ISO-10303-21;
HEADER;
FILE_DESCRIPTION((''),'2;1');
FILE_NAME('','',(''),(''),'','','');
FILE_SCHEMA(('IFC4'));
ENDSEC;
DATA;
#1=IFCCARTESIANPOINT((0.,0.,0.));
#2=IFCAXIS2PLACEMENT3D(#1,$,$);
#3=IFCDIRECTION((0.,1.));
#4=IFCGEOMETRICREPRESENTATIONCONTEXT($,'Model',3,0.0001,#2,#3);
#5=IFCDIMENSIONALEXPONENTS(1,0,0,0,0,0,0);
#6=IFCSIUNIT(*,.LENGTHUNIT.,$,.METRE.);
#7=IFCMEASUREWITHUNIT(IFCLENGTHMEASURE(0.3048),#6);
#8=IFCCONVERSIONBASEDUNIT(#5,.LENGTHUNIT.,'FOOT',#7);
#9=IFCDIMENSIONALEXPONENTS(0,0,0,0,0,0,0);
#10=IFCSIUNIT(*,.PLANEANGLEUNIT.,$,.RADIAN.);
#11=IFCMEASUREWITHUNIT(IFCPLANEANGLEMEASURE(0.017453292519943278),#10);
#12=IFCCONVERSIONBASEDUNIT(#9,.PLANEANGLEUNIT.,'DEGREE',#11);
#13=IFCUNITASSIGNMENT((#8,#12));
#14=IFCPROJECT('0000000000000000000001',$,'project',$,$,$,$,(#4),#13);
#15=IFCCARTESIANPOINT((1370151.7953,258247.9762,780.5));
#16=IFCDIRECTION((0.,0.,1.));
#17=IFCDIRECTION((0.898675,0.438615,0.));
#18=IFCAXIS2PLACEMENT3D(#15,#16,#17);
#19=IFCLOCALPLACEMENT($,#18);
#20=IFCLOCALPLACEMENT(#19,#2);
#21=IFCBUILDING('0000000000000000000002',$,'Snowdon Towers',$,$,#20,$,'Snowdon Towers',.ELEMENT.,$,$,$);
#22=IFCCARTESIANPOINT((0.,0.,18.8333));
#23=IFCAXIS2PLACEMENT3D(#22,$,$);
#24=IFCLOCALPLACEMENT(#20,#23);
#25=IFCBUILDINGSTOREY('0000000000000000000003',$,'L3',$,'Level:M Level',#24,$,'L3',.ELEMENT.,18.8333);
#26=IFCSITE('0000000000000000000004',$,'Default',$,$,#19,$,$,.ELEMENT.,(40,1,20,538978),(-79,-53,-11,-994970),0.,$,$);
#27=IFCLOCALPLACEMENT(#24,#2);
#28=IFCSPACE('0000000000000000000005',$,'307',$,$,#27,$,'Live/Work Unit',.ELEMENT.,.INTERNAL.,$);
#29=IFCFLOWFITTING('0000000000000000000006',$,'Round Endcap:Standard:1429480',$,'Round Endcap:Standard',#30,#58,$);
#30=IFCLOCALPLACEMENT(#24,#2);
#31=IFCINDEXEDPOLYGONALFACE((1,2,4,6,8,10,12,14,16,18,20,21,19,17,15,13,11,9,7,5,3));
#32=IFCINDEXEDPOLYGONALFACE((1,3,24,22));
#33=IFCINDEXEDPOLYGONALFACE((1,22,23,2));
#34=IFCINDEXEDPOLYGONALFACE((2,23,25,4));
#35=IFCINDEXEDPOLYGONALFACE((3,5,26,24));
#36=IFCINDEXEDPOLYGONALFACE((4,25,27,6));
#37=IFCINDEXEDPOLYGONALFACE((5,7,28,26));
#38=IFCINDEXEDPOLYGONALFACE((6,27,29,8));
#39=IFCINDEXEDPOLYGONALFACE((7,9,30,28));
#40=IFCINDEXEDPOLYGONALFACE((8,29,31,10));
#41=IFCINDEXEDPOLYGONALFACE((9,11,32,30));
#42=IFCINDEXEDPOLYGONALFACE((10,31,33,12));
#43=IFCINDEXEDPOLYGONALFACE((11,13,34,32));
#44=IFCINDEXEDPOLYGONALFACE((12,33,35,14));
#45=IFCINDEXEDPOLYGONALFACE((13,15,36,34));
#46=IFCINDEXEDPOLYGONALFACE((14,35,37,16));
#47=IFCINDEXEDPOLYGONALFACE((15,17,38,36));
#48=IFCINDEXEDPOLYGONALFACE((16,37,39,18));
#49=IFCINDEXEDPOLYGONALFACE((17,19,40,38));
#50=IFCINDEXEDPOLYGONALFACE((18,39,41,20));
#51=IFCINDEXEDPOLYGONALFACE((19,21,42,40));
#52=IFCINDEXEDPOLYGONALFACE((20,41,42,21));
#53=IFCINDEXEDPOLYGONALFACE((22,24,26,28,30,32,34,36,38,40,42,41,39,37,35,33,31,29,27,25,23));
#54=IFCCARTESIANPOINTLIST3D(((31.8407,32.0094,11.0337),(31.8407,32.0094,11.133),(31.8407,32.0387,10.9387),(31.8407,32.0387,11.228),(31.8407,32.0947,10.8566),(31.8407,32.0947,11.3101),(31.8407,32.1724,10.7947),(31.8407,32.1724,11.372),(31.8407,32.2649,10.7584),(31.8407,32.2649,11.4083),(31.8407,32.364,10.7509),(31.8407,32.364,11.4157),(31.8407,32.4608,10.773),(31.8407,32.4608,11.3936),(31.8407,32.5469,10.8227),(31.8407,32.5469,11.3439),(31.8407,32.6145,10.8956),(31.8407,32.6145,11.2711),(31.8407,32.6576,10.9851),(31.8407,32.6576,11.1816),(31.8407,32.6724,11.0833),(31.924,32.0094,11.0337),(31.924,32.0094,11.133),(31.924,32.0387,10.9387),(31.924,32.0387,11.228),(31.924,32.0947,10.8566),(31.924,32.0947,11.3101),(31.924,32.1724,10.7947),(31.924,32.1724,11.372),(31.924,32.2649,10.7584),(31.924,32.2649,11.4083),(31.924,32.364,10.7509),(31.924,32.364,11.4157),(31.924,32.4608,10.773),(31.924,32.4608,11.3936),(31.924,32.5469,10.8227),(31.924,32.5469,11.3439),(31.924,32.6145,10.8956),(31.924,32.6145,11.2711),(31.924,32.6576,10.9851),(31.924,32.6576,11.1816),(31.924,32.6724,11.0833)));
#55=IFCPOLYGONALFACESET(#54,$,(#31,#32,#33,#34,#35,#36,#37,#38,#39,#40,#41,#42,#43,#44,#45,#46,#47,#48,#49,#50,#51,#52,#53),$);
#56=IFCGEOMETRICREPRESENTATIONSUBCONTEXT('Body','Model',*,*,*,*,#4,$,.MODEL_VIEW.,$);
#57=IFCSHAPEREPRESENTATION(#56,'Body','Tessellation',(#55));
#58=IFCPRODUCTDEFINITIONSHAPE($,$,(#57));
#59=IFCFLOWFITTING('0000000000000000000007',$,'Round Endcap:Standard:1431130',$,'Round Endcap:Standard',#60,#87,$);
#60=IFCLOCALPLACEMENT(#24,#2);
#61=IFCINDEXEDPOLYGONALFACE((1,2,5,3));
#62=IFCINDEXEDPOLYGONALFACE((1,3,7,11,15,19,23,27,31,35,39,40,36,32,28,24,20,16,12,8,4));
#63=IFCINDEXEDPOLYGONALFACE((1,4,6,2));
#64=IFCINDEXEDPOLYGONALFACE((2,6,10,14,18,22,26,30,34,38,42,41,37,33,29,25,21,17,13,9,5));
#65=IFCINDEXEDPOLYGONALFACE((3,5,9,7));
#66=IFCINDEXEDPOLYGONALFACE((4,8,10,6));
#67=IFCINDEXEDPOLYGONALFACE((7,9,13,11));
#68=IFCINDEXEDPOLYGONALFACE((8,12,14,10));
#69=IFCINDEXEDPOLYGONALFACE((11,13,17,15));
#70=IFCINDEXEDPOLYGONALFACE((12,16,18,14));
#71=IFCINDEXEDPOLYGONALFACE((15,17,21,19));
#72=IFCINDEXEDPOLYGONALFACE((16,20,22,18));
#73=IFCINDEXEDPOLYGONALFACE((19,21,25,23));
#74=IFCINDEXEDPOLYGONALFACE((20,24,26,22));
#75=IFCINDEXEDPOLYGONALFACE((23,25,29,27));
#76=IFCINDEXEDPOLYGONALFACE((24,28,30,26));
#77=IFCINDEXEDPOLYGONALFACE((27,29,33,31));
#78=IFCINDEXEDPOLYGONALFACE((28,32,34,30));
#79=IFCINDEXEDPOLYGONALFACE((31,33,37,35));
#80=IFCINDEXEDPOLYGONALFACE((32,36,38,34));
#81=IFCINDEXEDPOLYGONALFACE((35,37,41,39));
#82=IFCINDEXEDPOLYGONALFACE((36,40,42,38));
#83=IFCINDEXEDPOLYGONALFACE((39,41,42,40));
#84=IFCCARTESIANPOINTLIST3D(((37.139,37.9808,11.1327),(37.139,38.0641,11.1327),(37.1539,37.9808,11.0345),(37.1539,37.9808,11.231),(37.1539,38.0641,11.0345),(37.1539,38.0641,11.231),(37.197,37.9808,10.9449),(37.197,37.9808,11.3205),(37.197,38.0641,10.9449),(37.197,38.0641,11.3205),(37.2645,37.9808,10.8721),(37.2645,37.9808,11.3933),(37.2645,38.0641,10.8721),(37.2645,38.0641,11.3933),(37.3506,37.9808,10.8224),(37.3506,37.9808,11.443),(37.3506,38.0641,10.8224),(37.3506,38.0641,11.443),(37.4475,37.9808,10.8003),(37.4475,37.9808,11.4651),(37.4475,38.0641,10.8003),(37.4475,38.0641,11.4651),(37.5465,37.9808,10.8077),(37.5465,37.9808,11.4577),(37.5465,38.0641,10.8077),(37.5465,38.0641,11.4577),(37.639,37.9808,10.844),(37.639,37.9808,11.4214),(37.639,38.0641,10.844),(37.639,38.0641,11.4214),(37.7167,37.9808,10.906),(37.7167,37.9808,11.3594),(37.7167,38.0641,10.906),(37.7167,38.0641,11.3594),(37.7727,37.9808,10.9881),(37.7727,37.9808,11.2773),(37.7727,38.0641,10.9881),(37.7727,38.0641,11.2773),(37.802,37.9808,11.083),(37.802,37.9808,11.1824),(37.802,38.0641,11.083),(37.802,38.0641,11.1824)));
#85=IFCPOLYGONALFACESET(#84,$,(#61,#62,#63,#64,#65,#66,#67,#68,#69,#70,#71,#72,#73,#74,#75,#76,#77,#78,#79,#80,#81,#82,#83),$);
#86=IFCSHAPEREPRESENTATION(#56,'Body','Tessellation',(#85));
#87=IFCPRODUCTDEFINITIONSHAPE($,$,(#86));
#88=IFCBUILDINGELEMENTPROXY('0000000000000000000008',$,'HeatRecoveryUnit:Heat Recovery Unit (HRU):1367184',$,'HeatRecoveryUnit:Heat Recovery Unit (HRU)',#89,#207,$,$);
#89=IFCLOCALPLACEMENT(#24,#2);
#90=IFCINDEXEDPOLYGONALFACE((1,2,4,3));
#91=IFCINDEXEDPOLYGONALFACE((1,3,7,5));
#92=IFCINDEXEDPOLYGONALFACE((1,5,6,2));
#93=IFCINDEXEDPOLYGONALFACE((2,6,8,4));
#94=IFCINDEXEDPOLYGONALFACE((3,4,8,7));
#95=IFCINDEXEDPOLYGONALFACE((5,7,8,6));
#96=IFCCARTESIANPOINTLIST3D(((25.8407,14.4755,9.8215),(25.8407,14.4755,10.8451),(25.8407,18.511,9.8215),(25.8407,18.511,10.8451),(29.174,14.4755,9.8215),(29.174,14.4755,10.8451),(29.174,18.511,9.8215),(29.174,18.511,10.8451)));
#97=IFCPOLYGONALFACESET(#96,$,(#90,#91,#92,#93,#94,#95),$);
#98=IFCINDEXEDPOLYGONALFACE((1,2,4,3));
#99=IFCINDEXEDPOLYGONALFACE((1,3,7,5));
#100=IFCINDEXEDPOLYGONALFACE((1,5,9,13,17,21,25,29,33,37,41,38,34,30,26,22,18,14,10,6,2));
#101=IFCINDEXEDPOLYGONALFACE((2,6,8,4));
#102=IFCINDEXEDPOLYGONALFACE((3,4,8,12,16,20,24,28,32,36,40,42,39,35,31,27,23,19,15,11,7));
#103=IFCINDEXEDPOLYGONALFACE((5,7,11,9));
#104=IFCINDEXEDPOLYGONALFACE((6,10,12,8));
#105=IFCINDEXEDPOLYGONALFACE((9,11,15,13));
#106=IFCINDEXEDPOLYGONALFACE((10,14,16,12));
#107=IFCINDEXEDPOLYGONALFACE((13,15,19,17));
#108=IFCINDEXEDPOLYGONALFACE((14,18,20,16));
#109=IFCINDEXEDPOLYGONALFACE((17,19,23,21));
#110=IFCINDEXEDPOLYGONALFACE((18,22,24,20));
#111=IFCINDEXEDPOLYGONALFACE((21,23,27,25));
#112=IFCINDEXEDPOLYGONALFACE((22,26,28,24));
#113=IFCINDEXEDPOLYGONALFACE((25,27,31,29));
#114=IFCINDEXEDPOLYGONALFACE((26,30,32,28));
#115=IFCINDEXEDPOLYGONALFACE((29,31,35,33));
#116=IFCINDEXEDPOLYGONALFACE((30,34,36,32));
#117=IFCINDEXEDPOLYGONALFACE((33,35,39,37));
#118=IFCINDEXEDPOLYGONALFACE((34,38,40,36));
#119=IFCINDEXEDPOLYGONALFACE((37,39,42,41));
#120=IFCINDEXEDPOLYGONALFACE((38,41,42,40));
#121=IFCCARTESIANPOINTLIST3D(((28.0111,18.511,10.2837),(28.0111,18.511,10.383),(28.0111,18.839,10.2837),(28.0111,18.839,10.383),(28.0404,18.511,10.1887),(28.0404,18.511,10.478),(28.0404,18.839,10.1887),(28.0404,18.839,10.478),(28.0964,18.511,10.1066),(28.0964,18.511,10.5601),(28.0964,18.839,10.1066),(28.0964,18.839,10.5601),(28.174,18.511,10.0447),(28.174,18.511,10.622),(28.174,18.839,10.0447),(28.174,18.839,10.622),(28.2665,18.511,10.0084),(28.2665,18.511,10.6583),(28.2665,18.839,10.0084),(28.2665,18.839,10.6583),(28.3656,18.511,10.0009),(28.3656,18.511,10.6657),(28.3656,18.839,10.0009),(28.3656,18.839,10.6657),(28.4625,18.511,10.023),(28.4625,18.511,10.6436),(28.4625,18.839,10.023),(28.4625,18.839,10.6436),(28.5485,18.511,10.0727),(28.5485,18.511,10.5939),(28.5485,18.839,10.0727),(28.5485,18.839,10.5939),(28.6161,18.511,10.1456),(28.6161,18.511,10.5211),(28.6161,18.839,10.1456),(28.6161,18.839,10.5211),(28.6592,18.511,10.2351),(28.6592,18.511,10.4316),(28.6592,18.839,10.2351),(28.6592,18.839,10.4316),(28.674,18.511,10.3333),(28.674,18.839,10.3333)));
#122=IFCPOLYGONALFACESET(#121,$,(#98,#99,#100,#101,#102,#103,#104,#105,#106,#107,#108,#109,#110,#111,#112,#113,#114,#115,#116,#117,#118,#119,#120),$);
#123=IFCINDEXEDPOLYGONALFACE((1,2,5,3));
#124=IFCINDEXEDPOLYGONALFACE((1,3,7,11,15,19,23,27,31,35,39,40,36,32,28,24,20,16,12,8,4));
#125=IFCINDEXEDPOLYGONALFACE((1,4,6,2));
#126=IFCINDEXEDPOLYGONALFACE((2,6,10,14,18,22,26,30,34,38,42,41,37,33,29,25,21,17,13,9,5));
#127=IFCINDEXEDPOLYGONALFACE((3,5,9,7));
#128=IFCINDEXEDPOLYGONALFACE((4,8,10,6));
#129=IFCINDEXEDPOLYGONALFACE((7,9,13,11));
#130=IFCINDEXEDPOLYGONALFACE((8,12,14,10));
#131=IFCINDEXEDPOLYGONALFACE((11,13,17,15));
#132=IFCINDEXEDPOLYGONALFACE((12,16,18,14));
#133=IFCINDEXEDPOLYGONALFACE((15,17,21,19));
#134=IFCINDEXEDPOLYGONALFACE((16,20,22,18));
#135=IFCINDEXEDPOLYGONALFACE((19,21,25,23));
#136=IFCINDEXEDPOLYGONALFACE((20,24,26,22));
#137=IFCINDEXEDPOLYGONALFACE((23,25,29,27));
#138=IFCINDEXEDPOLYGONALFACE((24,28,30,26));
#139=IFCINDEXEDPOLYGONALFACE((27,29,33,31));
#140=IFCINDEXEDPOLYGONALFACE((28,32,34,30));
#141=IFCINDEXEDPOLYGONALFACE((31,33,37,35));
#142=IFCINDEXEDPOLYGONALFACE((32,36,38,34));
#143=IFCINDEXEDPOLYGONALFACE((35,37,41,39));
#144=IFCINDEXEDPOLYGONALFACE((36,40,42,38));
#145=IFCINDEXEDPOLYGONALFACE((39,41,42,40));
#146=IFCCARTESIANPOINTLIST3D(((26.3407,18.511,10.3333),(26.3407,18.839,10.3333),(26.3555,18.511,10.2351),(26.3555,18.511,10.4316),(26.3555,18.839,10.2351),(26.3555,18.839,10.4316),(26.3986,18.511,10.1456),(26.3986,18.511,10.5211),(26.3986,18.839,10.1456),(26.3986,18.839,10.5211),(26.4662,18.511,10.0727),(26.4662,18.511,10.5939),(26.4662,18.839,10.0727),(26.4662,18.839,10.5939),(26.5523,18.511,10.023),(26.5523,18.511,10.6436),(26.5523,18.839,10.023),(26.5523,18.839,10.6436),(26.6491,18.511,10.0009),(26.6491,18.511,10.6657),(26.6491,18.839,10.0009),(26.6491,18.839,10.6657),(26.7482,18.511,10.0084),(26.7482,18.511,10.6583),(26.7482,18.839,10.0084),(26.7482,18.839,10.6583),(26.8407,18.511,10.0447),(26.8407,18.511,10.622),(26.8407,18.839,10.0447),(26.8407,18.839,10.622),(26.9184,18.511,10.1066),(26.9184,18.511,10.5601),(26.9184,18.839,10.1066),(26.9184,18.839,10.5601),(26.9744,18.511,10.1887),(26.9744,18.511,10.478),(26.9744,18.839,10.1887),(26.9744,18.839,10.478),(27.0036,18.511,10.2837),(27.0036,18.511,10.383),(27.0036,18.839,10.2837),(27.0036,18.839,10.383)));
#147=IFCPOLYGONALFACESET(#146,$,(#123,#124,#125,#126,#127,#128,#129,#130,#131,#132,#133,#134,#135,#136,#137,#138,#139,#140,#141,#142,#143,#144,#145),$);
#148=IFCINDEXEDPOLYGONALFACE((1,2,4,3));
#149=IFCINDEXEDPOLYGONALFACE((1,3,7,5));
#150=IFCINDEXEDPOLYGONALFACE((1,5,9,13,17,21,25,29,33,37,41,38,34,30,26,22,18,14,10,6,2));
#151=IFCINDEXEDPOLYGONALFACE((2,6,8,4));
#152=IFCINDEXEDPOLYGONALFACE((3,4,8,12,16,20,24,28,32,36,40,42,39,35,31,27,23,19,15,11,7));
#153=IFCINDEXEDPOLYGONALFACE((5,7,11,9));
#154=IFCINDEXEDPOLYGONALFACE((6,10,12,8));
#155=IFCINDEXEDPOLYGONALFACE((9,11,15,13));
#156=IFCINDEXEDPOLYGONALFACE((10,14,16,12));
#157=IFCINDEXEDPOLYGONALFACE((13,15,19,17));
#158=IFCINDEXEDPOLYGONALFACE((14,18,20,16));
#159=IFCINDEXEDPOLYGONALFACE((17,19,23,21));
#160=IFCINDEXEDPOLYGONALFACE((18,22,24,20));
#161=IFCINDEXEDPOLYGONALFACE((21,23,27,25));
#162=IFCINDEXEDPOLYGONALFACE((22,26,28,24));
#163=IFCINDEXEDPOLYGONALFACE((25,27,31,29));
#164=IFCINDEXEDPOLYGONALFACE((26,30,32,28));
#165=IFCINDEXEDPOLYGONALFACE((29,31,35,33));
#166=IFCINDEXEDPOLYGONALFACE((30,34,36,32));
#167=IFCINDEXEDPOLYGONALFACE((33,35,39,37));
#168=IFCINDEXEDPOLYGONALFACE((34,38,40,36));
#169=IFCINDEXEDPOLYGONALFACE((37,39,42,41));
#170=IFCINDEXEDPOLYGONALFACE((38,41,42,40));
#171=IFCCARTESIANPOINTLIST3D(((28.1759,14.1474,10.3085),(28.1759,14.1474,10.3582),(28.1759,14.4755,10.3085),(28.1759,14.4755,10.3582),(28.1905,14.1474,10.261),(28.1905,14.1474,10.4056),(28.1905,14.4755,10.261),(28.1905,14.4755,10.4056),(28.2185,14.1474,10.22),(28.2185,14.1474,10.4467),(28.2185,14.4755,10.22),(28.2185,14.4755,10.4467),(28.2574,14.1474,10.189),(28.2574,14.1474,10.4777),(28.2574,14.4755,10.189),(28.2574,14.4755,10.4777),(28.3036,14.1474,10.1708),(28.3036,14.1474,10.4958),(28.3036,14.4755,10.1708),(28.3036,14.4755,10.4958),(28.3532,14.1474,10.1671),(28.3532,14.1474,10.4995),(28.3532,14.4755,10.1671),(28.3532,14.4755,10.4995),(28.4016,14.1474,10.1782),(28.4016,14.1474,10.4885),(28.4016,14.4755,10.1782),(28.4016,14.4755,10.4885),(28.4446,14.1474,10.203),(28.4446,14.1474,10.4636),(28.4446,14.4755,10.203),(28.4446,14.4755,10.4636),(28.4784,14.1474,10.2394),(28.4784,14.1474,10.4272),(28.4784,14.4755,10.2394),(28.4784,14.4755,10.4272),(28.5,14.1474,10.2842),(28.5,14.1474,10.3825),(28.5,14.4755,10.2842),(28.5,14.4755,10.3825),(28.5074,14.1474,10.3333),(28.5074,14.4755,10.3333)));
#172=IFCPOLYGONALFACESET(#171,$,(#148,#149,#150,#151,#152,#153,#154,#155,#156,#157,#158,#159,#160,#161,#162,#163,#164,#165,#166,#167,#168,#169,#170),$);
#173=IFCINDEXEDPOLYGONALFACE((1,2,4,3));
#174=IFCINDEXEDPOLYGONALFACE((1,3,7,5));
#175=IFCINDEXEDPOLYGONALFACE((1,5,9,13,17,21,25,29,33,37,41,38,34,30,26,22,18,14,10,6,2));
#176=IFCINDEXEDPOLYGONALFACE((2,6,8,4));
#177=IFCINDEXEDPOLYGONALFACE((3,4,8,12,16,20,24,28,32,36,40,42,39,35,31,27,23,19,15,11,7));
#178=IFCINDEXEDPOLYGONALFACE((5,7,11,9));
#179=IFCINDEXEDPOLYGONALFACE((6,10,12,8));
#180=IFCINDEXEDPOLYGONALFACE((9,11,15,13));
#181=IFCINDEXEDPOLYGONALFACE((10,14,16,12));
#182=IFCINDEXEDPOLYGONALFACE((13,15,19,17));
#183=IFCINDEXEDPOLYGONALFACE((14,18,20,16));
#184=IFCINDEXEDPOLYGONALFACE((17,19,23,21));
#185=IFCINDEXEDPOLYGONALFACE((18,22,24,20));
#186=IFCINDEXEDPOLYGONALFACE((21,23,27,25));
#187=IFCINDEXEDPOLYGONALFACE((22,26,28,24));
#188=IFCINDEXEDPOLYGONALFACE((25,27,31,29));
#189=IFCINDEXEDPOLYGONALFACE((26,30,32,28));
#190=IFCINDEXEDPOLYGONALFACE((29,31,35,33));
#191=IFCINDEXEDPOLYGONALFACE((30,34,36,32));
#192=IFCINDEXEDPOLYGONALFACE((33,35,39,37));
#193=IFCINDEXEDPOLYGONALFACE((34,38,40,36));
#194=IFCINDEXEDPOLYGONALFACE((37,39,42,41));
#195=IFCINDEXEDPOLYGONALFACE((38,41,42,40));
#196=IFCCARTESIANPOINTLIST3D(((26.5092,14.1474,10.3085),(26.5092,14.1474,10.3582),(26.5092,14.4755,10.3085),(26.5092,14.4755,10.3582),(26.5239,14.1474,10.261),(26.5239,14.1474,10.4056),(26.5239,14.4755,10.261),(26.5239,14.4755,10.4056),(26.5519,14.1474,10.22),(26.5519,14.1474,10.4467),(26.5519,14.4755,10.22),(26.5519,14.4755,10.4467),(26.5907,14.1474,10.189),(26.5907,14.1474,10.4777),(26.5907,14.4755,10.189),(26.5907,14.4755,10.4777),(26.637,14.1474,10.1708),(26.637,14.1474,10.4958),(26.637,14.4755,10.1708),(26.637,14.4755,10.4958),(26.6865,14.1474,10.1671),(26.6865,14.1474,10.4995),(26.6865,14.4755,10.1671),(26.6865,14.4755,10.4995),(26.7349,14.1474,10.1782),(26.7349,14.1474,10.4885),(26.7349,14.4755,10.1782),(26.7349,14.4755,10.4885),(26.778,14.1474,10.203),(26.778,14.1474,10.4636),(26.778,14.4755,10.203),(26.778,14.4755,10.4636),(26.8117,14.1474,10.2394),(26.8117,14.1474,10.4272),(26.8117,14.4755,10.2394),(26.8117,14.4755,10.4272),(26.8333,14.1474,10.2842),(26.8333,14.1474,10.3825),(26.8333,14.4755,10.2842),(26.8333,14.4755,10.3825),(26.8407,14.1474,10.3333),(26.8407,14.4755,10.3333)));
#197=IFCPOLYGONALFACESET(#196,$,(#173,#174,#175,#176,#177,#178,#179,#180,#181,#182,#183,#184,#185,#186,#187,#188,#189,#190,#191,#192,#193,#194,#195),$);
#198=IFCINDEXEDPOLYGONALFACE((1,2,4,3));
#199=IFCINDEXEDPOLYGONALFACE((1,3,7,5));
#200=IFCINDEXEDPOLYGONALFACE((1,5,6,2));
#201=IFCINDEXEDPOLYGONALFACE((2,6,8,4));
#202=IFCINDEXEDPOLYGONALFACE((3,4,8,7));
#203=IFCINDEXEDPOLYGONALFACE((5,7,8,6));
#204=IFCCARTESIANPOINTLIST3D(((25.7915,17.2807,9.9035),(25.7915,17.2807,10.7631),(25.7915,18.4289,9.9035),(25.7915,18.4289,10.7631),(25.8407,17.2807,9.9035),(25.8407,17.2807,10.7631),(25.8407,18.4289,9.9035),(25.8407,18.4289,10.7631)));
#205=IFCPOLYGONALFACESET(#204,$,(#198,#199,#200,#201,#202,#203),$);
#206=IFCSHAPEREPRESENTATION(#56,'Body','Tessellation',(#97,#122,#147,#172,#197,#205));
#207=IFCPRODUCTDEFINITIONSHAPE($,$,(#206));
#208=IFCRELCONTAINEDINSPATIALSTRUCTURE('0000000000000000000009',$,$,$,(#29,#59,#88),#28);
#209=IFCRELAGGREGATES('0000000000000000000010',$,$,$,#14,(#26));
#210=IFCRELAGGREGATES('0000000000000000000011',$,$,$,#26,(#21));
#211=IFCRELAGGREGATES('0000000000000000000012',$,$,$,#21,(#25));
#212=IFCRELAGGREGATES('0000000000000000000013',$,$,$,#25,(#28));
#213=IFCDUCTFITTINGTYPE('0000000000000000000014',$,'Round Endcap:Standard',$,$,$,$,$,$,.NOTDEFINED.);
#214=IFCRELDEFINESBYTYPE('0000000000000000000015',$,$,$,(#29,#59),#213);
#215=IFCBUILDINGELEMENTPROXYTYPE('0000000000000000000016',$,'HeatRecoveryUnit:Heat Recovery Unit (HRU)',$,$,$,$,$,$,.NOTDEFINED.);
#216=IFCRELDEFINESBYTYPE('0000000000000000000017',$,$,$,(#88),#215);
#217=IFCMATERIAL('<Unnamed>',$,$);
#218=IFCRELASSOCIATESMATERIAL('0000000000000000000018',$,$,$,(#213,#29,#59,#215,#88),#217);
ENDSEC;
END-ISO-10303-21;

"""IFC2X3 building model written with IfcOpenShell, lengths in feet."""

from ifc_helpers import new_model, entity, si_unit, converted_unit, direction, frame, frame_2d, origin, origin_2d_with_axis, place, context, subcontext, project, spatial, rectangle, circle, extrude, source, transform, mapped, material, type_object, type_shapes, element, save


model = new_model("IFC2X3")

# Units and contexts
model_context = context("Model", 3, precision=0.0001, world=origin(), true_north=direction((0.0, 1.0)))
body_context = subcontext(model_context, "Body", "Model", "MODEL_VIEW")
ifc_project = project(units=[converted_unit("LENGTHUNIT", "FOOT", entity("IfcLengthMeasure", 0.3048), si_unit("LENGTHUNIT", "METRE"), dimensions=[1, 0, 0, 0, 0, 0, 0]), converted_unit("PLANEANGLEUNIT", "DEGREE", entity("IfcPlaneAngleMeasure", 0.017453292519943278), si_unit("PLANEANGLEUNIT", "RADIAN"), dimensions=[0, 0, 0, 0, 0, 0, 0])], contexts=[model_context])

# Site, building, storey
site_placement = place(None, frame((1370151.7953, 258247.9762, 780.5), z_axis=(0.0, 0.0, 1.0), x_axis=(0.898675, 0.438615, 0.0)))
site = spatial("IfcSite", under=ifc_project, at=site_placement, Name="Default", CompositionType="ELEMENT", RefLatitude=(40, 1, 20, 538978), RefLongitude=(-79, -53, -11, -994970), RefElevation=0.0)
building_placement = place(site_placement, origin())
building = spatial("IfcBuilding", under=site, at=building_placement, Name="Snowdon Towers", LongName="Snowdon Towers", CompositionType="ELEMENT")
storey_placement = place(building_placement, frame((0.0, 0.0, 18.8333)))
storey = spatial("IfcBuildingStorey", under=building, at=storey_placement, Name="L3", ObjectType="Level:M Level", LongName="L3", CompositionType="ELEMENT", Elevation=18.8333)

# Shared definitions
space_placement = place(storey_placement, origin())
space = spatial("IfcSpace", under=storey, at=space_placement, Name="307", LongName="Live/Work Unit", CompositionType="ELEMENT", InteriorOrExteriorSpace="INTERNAL")

# Flow fittings
ifc_material = material(Name="<Unnamed>")
duct_fitting_type = type_object("IfcDuctFittingType", Name="Round Endcap:Standard", PredefinedType="NOTDEFINED", material=ifc_material)
shared_shape_1 = source(origin(), body_context, "Body", "SweptSolid", [
    extrude(circle(Radius=0.3333, at=frame_2d((0.0, 0.0), x_axis=(1.0, 0.0))), frame((0.0, 0.0, 0.0), z_axis=(1.0, 0.0, 0.0), x_axis=(0.0, 1.0, 0.0)), (0.0, 0.0, 1.0), 0.0833),
])
type_shapes(duct_fitting_type, [shared_shape_1])
flow_fitting_1_placement = place(space_placement, frame((31.8407, 32.339, 11.0833)))
element("IfcFlowFitting", 1, at=flow_fitting_1_placement, inside=space, type_object=duct_fitting_type, material=ifc_material, Name="Round Endcap:Standard:1429480", ObjectType="Round Endcap:Standard", context=body_context, shape_type="MappedRepresentation", body=[
    mapped(shared_shape_1, transform((0.0, 0.0, 0.0), scale=1.0)),
])
flow_fitting_2_placement = place(space_placement, frame((37.4724, 37.9808, 11.1327), z_axis=(0.0, 0.0, 1.0), x_axis=(0.0, 1.0, 0.0)))
element("IfcFlowFitting", 2, at=flow_fitting_2_placement, inside=space, type_object=duct_fitting_type, material=ifc_material, Name="Round Endcap:Standard:1431130", ObjectType="Round Endcap:Standard", context=body_context, shape_type="MappedRepresentation", body=[
    mapped(shared_shape_1, transform((0.0, 0.0, 0.0), scale=1.0)),
])

# Building element proxy
building_element_proxy_type = type_object("IfcBuildingElementProxyType", Name="HeatRecoveryUnit:Heat Recovery Unit (HRU)", PredefinedType="NOTDEFINED", material=ifc_material)
shared_shape_2 = source(origin(), body_context, "Body", "SweptSolid", [
    extrude(rectangle(XDim=3.3333, YDim=4.0354, at=origin_2d_with_axis()), frame((0.0, 0.0, 0.0), z_axis=(0.0, 0.0, 1.0), x_axis=(-1.0, 0.0, 0.0)), (0.0, 0.0, 1.0), 1.0236),
    extrude(circle(Radius=0.3333, at=frame_2d((0.0, 0.0), x_axis=(1.0, 0.0))), frame((-0.8333, -2.3458, 0.5118), z_axis=(0.0, 1.0, 0.0), x_axis=(-1.0, 0.0, 0.0)), (0.0, 0.0, 1.0), 0.3281),
    extrude(circle(Radius=0.3333, at=frame_2d((0.0, 0.0), x_axis=(1.0, 0.0))), frame((0.8333, -2.3458, 0.5118), z_axis=(0.0, 1.0, 0.0), x_axis=(1.0, 0.0, 0.0)), (0.0, 0.0, 1.0), 0.3281),
    extrude(circle(Radius=0.1667, at=frame_2d((0.0, 0.0), x_axis=(1.0, 0.0))), frame((-0.8333, 2.0177, 0.5118), z_axis=(0.0, 1.0, 0.0), x_axis=(-1.0, 0.0, 0.0)), (0.0, 0.0, 1.0), 0.3281),
    extrude(circle(Radius=0.1667, at=frame_2d((0.0, 0.0), x_axis=(1.0, 0.0))), frame((0.8333, 2.0177, 0.5118), z_axis=(0.0, 1.0, 0.0), x_axis=(-1.0, 0.0, 0.0)), (0.0, 0.0, 1.0), 0.3281),
    extrude(rectangle(XDim=0.0492, YDim=1.1483, at=origin_2d_with_axis()), frame((1.6913, -1.3615, 0.082), z_axis=(0.0, 0.0, 1.0), x_axis=(-1.0, 0.0, 0.0)), (0.0, 0.0, 1.0), 0.8596),
])
type_shapes(building_element_proxy_type, [shared_shape_2])
proxy_placement = place(space_placement, frame((27.5074, 16.4932, 9.8215), z_axis=(0.0, 0.0, 1.0), x_axis=(-1.0, 0.0, 0.0)))
element("IfcBuildingElementProxy", 3, at=proxy_placement, inside=space, type_object=building_element_proxy_type, material=ifc_material, Name="HeatRecoveryUnit:Heat Recovery Unit (HRU):1367184", ObjectType="HeatRecoveryUnit:Heat Recovery Unit (HRU)", context=body_context, shape_type="MappedRepresentation", body=[
    mapped(shared_shape_2, transform((0.0, 0.0, 0.0), scale=1.0)),
])

save(model, "model.ifc")
